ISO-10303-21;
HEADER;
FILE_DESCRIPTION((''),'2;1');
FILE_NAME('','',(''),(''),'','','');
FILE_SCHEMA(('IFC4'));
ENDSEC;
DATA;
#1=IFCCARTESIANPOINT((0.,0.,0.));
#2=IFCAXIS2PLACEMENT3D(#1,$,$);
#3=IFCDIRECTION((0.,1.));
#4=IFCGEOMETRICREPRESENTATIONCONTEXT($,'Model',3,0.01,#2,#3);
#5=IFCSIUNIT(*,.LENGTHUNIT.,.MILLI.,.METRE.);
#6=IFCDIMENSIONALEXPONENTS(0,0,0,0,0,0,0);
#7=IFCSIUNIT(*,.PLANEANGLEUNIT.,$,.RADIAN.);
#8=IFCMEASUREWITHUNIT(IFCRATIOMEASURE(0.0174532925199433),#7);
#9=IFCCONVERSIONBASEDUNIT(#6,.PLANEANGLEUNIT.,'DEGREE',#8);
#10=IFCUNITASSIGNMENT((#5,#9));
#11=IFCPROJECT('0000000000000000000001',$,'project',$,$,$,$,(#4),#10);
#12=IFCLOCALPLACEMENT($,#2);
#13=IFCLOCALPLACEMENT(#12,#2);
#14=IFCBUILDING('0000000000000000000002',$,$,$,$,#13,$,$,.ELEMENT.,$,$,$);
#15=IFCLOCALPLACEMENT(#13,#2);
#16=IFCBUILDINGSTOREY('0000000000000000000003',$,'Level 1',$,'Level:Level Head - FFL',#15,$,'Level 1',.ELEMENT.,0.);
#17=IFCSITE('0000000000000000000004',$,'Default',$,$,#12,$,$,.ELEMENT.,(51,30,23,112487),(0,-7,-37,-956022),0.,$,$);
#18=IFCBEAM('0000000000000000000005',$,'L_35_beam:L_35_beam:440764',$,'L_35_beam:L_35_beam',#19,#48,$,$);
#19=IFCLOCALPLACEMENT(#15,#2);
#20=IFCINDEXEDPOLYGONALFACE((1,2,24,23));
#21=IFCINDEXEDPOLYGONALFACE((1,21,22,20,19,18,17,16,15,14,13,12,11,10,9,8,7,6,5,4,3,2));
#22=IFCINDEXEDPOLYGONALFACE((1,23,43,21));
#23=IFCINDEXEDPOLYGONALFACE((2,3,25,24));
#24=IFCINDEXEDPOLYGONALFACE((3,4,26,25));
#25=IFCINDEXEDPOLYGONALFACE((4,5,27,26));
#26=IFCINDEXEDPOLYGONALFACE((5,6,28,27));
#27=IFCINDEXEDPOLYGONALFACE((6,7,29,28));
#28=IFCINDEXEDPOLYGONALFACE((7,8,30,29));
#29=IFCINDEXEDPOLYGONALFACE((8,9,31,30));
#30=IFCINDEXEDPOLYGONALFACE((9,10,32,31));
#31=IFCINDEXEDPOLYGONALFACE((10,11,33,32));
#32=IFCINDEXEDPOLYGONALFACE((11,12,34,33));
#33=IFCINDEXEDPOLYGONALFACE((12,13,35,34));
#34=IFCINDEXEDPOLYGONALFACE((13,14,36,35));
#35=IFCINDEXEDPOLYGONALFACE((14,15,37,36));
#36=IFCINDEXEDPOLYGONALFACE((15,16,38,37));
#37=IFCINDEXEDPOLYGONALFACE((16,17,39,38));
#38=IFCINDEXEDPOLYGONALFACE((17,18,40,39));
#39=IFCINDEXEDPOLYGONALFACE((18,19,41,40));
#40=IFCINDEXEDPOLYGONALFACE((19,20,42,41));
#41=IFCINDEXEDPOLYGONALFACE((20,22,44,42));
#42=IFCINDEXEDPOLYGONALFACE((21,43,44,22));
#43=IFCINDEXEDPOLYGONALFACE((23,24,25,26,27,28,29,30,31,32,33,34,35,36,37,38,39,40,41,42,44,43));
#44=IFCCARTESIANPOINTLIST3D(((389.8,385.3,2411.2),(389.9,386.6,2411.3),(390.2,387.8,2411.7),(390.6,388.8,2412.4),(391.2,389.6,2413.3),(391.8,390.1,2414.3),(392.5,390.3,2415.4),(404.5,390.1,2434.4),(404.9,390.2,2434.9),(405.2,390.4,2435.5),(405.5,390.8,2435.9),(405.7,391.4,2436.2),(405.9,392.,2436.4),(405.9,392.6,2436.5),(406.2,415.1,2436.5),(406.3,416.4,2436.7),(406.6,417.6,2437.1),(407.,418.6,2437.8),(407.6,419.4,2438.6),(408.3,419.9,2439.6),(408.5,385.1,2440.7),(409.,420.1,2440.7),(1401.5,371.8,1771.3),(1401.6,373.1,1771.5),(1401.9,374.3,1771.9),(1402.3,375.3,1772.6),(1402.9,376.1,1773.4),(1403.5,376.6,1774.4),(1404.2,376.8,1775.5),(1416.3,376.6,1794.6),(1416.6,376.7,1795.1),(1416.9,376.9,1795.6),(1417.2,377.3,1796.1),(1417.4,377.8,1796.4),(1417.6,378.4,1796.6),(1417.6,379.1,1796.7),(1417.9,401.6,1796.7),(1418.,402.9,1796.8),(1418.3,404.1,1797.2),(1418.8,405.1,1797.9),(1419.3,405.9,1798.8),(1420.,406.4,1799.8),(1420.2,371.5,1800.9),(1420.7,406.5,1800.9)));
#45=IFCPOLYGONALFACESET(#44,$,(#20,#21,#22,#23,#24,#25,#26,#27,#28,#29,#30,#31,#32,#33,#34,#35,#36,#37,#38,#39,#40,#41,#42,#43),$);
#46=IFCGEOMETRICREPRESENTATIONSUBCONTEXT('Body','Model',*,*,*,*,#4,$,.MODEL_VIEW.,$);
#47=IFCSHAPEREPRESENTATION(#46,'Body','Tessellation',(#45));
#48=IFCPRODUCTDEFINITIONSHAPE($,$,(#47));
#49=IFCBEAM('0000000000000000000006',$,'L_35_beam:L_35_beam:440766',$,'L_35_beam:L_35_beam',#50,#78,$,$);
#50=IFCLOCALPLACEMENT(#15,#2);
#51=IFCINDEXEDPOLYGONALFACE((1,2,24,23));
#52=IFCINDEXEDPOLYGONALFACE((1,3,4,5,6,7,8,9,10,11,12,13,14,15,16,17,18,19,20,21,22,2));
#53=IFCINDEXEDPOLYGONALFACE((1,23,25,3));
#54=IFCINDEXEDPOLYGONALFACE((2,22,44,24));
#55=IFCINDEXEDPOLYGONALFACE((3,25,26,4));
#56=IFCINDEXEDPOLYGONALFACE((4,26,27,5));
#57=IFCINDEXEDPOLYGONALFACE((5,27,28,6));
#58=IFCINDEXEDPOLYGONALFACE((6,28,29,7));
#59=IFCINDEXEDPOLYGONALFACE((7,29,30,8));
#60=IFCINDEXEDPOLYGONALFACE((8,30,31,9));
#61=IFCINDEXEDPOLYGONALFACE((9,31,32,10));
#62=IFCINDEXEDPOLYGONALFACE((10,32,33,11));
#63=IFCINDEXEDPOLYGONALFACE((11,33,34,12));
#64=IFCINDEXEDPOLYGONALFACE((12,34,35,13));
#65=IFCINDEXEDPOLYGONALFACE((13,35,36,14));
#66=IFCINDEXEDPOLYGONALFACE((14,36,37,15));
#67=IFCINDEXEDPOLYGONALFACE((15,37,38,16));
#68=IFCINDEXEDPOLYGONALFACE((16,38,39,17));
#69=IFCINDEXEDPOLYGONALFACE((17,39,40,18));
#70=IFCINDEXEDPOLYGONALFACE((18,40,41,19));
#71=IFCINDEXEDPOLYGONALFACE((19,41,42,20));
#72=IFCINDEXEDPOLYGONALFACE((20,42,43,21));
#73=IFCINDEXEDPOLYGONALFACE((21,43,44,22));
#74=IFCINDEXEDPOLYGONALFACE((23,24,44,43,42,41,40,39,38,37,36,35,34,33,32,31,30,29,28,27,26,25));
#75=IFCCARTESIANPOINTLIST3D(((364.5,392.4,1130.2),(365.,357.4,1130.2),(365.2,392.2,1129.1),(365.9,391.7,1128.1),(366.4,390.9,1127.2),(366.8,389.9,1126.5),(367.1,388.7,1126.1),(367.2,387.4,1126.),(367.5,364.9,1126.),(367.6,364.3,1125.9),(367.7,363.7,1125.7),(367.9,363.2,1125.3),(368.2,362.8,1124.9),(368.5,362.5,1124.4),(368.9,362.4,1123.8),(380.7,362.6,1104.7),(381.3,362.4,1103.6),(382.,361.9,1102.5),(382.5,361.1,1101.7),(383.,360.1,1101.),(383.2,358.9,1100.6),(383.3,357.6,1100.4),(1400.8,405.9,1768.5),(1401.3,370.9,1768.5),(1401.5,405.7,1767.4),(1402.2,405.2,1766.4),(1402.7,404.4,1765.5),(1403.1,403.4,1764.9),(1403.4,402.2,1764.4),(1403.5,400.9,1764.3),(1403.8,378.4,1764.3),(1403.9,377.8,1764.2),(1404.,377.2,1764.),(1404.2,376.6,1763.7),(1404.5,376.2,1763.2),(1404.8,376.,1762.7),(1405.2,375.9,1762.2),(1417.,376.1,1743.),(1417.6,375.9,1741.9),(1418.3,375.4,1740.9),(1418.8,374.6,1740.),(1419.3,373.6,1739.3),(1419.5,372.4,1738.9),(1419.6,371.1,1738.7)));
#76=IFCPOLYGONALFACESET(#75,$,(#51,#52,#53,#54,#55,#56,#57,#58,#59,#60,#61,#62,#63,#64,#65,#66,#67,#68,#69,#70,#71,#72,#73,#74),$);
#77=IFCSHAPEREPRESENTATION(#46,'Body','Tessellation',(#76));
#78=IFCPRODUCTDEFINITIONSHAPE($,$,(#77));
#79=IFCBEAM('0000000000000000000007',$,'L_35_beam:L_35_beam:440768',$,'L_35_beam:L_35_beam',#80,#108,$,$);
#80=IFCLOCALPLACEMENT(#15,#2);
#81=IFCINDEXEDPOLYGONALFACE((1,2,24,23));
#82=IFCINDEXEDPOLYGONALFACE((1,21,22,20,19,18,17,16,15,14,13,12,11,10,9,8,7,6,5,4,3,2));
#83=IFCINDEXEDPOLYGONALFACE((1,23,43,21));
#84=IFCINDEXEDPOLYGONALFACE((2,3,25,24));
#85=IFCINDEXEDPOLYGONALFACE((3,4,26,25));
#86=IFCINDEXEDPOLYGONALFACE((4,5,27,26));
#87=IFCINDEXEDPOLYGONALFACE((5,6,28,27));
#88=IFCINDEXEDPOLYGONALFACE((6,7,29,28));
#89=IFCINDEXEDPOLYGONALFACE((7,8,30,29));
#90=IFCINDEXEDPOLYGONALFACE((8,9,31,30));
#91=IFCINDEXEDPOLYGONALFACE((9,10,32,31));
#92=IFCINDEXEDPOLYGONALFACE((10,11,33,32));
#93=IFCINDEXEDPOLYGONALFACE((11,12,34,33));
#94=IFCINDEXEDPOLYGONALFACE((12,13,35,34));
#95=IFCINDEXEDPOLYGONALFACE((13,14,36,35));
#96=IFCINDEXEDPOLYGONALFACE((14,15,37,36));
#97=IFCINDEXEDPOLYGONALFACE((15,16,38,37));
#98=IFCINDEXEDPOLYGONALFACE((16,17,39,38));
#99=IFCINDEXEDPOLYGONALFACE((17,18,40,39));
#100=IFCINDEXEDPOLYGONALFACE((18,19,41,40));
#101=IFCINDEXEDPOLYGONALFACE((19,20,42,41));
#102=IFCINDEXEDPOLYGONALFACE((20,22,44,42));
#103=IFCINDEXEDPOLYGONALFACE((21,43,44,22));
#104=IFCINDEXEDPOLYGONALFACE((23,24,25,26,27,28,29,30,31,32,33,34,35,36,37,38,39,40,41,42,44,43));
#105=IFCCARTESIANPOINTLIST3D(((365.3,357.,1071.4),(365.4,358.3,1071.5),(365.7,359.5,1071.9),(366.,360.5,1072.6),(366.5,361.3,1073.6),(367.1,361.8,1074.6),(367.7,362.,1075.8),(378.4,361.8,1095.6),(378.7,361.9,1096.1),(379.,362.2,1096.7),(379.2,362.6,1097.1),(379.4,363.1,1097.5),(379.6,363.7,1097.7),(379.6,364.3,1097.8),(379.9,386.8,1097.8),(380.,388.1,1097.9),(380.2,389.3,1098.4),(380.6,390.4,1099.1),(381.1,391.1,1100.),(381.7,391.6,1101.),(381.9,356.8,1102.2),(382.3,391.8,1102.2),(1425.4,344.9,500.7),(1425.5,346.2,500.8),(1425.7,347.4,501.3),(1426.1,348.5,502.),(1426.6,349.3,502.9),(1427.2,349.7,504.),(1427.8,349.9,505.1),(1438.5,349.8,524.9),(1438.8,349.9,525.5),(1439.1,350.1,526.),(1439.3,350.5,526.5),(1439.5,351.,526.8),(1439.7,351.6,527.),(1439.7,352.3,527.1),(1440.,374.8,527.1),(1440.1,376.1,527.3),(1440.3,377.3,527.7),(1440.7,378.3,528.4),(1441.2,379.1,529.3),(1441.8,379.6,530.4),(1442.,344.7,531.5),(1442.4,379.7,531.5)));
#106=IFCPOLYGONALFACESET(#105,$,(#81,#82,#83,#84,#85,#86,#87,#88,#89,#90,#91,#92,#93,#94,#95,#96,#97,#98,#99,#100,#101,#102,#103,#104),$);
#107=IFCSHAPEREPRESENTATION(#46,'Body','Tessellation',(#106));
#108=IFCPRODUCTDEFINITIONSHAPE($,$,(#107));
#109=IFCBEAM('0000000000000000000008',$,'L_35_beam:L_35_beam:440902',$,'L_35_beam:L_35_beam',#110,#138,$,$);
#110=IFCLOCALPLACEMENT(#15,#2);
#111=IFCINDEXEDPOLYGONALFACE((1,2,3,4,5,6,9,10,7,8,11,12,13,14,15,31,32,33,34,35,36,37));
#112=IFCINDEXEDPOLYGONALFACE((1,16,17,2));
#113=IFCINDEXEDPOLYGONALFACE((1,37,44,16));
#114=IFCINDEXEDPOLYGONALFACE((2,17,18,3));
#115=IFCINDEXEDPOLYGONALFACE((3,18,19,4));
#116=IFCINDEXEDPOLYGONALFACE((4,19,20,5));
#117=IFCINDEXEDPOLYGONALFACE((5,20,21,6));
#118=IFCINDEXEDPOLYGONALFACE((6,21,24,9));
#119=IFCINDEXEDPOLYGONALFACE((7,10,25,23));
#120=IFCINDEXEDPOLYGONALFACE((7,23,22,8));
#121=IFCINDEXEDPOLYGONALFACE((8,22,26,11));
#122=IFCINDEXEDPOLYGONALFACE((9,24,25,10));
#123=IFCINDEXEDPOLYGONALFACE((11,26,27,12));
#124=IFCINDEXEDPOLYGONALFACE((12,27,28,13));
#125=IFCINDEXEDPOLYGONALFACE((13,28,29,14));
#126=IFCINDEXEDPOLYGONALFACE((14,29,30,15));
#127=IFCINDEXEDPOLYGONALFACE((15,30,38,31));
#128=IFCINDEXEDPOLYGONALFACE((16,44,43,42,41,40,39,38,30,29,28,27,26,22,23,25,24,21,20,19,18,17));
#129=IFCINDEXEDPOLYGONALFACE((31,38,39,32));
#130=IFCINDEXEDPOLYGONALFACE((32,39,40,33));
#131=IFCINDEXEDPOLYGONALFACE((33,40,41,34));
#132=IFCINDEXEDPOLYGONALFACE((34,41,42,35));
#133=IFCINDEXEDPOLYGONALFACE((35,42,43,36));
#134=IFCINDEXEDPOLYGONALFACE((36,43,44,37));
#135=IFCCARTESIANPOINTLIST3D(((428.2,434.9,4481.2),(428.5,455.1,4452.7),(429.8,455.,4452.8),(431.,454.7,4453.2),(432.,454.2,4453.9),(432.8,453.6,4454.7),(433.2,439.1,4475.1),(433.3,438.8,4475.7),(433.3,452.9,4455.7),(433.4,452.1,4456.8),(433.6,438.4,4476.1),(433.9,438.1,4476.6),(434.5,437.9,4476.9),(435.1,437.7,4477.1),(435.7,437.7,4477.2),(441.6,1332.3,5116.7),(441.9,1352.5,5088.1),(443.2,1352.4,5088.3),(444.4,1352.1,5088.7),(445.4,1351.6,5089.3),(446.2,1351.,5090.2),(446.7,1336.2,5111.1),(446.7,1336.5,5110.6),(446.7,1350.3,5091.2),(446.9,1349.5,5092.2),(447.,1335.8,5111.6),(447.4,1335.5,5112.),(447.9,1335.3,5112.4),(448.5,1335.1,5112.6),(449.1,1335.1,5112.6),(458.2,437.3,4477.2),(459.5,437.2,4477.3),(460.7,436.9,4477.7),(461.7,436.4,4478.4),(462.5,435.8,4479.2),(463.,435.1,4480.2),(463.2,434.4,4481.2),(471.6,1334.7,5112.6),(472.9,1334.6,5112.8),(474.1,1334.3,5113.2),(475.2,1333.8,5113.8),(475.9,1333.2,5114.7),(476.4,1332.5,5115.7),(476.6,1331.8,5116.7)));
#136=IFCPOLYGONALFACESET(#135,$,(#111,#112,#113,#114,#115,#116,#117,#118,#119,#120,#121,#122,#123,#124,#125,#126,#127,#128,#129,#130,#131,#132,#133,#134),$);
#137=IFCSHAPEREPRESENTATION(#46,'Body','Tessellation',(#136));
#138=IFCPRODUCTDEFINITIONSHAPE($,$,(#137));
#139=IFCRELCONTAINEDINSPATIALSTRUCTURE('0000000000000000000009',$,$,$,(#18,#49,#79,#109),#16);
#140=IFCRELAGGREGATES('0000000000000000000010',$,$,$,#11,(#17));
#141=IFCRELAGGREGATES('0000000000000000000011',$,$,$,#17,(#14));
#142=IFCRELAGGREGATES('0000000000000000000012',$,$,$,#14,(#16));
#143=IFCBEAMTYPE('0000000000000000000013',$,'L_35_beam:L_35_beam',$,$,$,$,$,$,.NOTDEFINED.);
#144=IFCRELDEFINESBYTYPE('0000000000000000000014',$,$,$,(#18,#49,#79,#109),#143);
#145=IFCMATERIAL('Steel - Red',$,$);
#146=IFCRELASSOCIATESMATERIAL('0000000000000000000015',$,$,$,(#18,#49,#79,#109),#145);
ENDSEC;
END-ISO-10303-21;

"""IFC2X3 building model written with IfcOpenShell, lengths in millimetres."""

from ifc_helpers import new_model, entity, si_unit, converted_unit, direction, frame, frame_2d, origin, place, context, subcontext, project, spatial, polyline, circle_curve, parameter, trimmed, segment, composite_curve, outline, extrude, material, type_object, element, save


model = new_model("IFC2X3")

# Units and contexts
model_context = context("Model", 3, precision=0.01, world=origin(), true_north=direction((0.0, 1.0)))
body_context = subcontext(model_context, "Body", "Model", "MODEL_VIEW")
ifc_project = project(units=[si_unit("LENGTHUNIT", "METRE", prefix="MILLI"), converted_unit("PLANEANGLEUNIT", "DEGREE", entity("IfcRatioMeasure", 0.0174532925199433), si_unit("PLANEANGLEUNIT", "RADIAN"), dimensions=[0, 0, 0, 0, 0, 0, 0])], contexts=[model_context])

# Site, building, storey
site_placement = place(None, origin())
site = spatial("IfcSite", under=ifc_project, at=site_placement, Name="Default", CompositionType="ELEMENT", RefLatitude=(51, 30, 23, 112487), RefLongitude=(0, -7, -37, -956022), RefElevation=0.0)
building_placement = place(site_placement, origin())
building = spatial("IfcBuilding", under=site, at=building_placement, CompositionType="ELEMENT")
storey_placement = place(building_placement, origin())
storey = spatial("IfcBuildingStorey", under=building, at=storey_placement, Name="Level 1", ObjectType="Level:Level Head - FFL", LongName="Level 1", CompositionType="ELEMENT", Elevation=0.0)

# Beams
ifc_material_1 = material(Name="Steel - Red")
beam_type = type_object("IfcBeamType", Name="L_35_beam:L_35_beam", PredefinedType="NOTDEFINED")
beam_1_placement = place(storey_placement, frame((1436.7, 363.3, 1769.7), z_axis=(0.534423, -0.007141, 0.845187), x_axis=(-0.845111, 0.011293, 0.534471)))
element("IfcBeam", 1, at=beam_1_placement, inside=storey, type_object=beam_type, material=ifc_material_1, Name="L_35_beam:L_35_beam:440764", ObjectType="L_35_beam:L_35_beam", context=body_context, shape_type="SweptSolid", body=[
    extrude(outline(composite_curve([segment(polyline([(-23.2, -11.8), (11.8, -11.8)]), True, "CONTINUOUS"), segment(polyline([(11.8, -11.8), (11.8, 23.2)]), True, "CONTINUOUS"), segment(trimmed(circle_curve(frame_2d((11.8, 18.2), x_axis=(0.0, 1.0)), 5.0), [parameter(0.0)], [parameter(90.0)], True, "PARAMETER"), True, "CONTINUOUS"), segment(polyline([(6.8, 18.2), (6.8, -4.3)]), True, "CONTINUOUS"), segment(trimmed(circle_curve(frame_2d((4.3, -4.3), x_axis=(1.0, 0.0)), 2.5), [parameter(270.0)], [parameter(0.0)], True, "PARAMETER"), False, "CONTINUOUS"), segment(polyline([(4.3, -6.8), (-18.2, -6.8)]), True, "CONTINUOUS"), segment(trimmed(circle_curve(frame_2d((-18.2, -11.8), x_axis=(0.0, 1.0)), 5.0), [parameter(0.0)], [parameter(90.0)], True, "PARAMETER"), True, "CONTINUOUS")], self_intersect=False)), frame((30.7, -19.8, 5.7), z_axis=(1.0, 0.0, 0.0), x_axis=(0.0, 0.0, 1.0)), (0.0, 0.0, 1.0), 1197.1),
])
beam_2_placement = place(storey_placement, frame((1436.7, 363.3, 1769.7), z_axis=(-0.524377, -0.006825, 0.851459), x_axis=(-0.851387, -0.011081, -0.524421)))
element("IfcBeam", 2, at=beam_2_placement, inside=storey, type_object=beam_type, material=ifc_material_1, Name="L_35_beam:L_35_beam:440766", ObjectType="L_35_beam:L_35_beam", context=body_context, shape_type="SweptSolid", body=[
    extrude(outline(composite_curve([segment(polyline([(-23.2, -11.8), (11.8, -11.8)]), True, "CONTINUOUS"), segment(polyline([(11.8, -11.8), (11.8, 23.2)]), True, "CONTINUOUS"), segment(trimmed(circle_curve(frame_2d((11.8, 18.2), x_axis=(0.0, 1.0)), 5.0), [parameter(0.0)], [parameter(90.0)], True, "PARAMETER"), True, "CONTINUOUS"), segment(polyline([(6.8, 18.2), (6.8, -4.3)]), True, "CONTINUOUS"), segment(trimmed(circle_curve(frame_2d((4.3, -4.3), x_axis=(1.0, 0.0)), 2.5), [parameter(270.0)], [parameter(0.0)], True, "PARAMETER"), False, "CONTINUOUS"), segment(polyline([(4.3, -6.8), (-18.2, -6.8)]), True, "CONTINUOUS"), segment(trimmed(circle_curve(frame_2d((-18.2, -11.8), x_axis=(0.0, 1.0)), 5.0), [parameter(0.0)], [parameter(90.0)], True, "PARAMETER"), True, "CONTINUOUS")], self_intersect=False)), frame((30.6, -19.8, 5.7), z_axis=(1.0, 0.0, 0.0), x_axis=(0.0, 0.0, 1.0)), (0.0, 0.0, 1.0), 1217.2),
])
beam_3_placement = place(storey_placement, frame((1463.5, 336.5, 500.0), z_axis=(0.473951, -0.005391, 0.880535), x_axis=(-0.880478, 0.010015, 0.473982)))
element("IfcBeam", 3, at=beam_3_placement, inside=storey, type_object=beam_type, material=ifc_material_1, Name="L_35_beam:L_35_beam:440768", ObjectType="L_35_beam:L_35_beam", context=body_context, shape_type="SweptSolid", body=[
    extrude(outline(composite_curve([segment(polyline([(-23.2, -11.8), (11.8, -11.8)]), True, "CONTINUOUS"), segment(polyline([(11.8, -11.8), (11.8, 23.2)]), True, "CONTINUOUS"), segment(trimmed(circle_curve(frame_2d((11.8, 18.2), x_axis=(0.0, 1.0)), 5.0), [parameter(0.0)], [parameter(90.0)], True, "PARAMETER"), True, "CONTINUOUS"), segment(polyline([(6.8, 18.2), (6.8, -4.3)]), True, "CONTINUOUS"), segment(trimmed(circle_curve(frame_2d((4.3, -4.3), x_axis=(1.0, 0.0)), 2.5), [parameter(270.0)], [parameter(0.0)], True, "PARAMETER"), False, "CONTINUOUS"), segment(polyline([(4.3, -6.8), (-18.2, -6.8)]), True, "CONTINUOUS"), segment(trimmed(circle_curve(frame_2d((-18.2, -11.8), x_axis=(0.0, 1.0)), 5.0), [parameter(0.0)], [parameter(90.0)], True, "PARAMETER"), True, "CONTINUOUS")], self_intersect=False)), frame((34.0, -19.8, 5.7), z_axis=(1.0, 0.0, 0.0), x_axis=(0.0, 0.0, 1.0)), (0.0, 0.0, 1.0), 1204.0),
])
beam_4_placement = place(storey_placement, frame((419.9, 420.0, 4449.2), z_axis=(-0.008645, -0.577789, 0.81614), x_axis=(0.01221, 0.816049, 0.577854)))
element("IfcBeam", 4, at=beam_4_placement, inside=storey, type_object=beam_type, material=ifc_material_1, Name="L_35_beam:L_35_beam:440902", ObjectType="L_35_beam:L_35_beam", context=body_context, shape_type="SweptSolid", body=[
    extrude(outline(composite_curve([segment(polyline([(-23.2, -11.8), (11.8, -11.8)]), True, "CONTINUOUS"), segment(polyline([(11.8, -11.8), (11.8, 23.2)]), True, "CONTINUOUS"), segment(trimmed(circle_curve(frame_2d((11.8, 18.2), x_axis=(0.0, 1.0)), 5.0), [parameter(0.0)], [parameter(90.0)], True, "PARAMETER"), True, "CONTINUOUS"), segment(polyline([(6.8, 18.2), (6.8, -4.3)]), True, "CONTINUOUS"), segment(trimmed(circle_curve(frame_2d((4.3, -4.3), x_axis=(1.0, 0.0)), 2.5), [parameter(270.0)], [parameter(0.0)], True, "PARAMETER"), False, "CONTINUOUS"), segment(polyline([(4.3, -6.8), (-18.2, -6.8)]), True, "CONTINUOUS"), segment(trimmed(circle_curve(frame_2d((-18.2, -11.8), x_axis=(0.0, 1.0)), 5.0), [parameter(0.0)], [parameter(90.0)], True, "PARAMETER"), True, "CONTINUOUS")], self_intersect=False)), frame((30.8, -19.8, 5.7), z_axis=(1.0, 0.0, 0.0), x_axis=(0.0, 0.0, 1.0)), (0.0, 0.0, 1.0), 1099.7),
])

save(model, "model.ifc")
